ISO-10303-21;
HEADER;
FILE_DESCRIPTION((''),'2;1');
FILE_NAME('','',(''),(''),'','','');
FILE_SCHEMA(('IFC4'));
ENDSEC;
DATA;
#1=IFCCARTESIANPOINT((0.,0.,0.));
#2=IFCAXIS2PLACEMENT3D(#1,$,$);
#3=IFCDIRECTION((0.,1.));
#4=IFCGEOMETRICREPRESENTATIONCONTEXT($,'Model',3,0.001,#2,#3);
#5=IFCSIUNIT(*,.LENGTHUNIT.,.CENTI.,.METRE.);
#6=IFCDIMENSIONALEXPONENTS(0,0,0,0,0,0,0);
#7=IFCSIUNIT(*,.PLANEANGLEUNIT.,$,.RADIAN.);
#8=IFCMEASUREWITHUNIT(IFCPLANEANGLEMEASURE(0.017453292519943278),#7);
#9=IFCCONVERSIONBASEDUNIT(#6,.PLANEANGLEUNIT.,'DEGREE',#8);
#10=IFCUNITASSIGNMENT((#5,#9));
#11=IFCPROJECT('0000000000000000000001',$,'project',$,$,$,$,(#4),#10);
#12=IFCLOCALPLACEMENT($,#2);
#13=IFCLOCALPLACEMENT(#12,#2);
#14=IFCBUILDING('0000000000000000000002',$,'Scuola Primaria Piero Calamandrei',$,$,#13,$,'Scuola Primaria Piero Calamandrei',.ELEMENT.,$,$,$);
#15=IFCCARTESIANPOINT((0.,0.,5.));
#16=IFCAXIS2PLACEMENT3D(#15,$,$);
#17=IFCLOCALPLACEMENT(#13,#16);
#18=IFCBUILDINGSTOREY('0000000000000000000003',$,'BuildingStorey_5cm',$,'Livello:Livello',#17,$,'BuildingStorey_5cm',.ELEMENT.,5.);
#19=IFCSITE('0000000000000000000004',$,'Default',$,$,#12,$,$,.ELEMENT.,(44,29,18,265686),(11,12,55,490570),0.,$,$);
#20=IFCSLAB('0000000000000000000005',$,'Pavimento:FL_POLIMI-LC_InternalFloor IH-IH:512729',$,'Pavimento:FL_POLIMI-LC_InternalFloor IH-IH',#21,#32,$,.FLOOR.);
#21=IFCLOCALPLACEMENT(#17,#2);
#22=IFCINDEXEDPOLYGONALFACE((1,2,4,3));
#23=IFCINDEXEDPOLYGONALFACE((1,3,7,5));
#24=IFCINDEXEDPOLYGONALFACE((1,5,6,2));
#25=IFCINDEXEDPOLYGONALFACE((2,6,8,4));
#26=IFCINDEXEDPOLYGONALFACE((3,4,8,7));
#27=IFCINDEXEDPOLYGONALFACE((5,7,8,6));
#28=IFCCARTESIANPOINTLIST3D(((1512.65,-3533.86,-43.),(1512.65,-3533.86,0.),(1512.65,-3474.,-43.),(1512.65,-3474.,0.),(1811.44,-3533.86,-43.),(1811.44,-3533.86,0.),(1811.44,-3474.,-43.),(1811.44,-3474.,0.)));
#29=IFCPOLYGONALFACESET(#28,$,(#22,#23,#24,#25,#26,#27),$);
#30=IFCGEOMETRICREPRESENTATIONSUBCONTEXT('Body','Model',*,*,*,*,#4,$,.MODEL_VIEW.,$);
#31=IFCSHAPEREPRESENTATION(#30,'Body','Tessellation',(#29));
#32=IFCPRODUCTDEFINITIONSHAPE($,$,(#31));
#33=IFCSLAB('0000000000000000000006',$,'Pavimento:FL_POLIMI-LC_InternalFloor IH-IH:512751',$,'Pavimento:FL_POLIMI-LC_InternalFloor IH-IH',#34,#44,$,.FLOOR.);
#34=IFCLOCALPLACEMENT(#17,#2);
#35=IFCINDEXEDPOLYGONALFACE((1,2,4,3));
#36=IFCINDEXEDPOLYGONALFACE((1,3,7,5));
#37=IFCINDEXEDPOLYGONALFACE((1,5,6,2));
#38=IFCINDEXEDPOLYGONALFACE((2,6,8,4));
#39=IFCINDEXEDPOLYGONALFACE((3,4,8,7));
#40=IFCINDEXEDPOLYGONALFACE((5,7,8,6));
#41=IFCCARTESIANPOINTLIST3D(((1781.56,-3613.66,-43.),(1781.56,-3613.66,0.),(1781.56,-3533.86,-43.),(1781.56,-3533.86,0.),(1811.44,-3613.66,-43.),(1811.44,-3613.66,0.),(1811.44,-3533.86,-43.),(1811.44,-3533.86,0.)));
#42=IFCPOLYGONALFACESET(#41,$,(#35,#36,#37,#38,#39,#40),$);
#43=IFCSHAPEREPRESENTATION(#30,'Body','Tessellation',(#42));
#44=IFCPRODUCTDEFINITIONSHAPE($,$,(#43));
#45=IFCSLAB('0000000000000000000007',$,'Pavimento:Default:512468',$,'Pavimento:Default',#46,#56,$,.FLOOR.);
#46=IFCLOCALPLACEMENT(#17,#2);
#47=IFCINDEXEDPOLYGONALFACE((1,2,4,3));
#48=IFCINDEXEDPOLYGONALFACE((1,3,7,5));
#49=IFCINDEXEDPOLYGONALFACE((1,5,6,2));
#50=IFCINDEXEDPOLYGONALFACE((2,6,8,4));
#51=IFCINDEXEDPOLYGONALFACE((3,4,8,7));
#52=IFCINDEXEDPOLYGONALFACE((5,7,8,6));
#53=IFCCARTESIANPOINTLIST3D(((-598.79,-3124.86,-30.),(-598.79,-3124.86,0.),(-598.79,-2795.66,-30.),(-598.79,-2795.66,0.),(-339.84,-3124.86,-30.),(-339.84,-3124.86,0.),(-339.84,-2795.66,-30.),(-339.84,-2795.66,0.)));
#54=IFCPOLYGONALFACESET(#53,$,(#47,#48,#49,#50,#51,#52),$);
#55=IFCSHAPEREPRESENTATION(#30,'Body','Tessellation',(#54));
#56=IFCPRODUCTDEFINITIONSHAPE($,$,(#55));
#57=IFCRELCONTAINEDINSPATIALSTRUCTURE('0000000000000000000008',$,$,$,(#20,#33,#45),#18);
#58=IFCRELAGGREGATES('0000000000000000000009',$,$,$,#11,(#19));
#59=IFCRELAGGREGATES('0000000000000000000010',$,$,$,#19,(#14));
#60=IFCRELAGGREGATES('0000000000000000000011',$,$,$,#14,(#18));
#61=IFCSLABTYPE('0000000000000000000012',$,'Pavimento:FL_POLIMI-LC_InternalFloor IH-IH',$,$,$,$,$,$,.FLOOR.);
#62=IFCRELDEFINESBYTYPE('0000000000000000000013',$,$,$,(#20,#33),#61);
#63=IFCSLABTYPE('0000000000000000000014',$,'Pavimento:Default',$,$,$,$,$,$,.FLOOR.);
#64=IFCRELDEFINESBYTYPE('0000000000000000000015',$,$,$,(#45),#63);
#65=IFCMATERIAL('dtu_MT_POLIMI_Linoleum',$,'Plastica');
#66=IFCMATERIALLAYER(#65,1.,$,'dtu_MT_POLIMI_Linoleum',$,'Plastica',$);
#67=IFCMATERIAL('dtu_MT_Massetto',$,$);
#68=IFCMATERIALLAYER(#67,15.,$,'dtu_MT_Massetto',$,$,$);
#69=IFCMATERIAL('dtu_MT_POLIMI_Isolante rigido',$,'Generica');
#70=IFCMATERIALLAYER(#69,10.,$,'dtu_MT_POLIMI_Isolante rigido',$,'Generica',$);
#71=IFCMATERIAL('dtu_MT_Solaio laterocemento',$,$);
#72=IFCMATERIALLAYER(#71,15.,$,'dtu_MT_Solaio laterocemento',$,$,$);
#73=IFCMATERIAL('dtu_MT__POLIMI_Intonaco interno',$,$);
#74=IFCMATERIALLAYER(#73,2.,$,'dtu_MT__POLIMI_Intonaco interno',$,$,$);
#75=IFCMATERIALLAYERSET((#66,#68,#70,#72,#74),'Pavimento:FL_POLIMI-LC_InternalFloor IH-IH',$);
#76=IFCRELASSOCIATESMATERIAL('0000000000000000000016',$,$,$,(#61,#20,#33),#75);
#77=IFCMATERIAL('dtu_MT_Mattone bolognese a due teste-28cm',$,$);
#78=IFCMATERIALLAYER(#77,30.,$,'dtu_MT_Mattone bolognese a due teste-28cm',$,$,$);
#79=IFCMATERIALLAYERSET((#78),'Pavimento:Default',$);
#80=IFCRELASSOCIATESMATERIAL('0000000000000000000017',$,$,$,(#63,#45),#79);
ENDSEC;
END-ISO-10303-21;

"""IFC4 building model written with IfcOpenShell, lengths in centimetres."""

from ifc_helpers import new_model, entity, si_unit, converted_unit, direction, frame, frame_2d, origin, place, context, subcontext, project, spatial, rectangle, extrude, material, layer, layer_set, layer_usage, type_object, element, save


model = new_model("IFC4")

# Units and contexts
model_context = context("Model", 3, precision=0.001, world=origin(), true_north=direction((0.0, 1.0)))
body_context = subcontext(model_context, "Body", "Model", "MODEL_VIEW")
ifc_project = project(units=[si_unit("LENGTHUNIT", "METRE", prefix="CENTI"), converted_unit("PLANEANGLEUNIT", "DEGREE", entity("IfcPlaneAngleMeasure", 0.017453292519943278), si_unit("PLANEANGLEUNIT", "RADIAN"), dimensions=[0, 0, 0, 0, 0, 0, 0])], contexts=[model_context])

# Site, building, storey
site_placement = place(None, origin())
site = spatial("IfcSite", under=ifc_project, at=site_placement, Name="Default", CompositionType="ELEMENT", RefLatitude=(44, 29, 18, 265686), RefLongitude=(11, 12, 55, 490570), RefElevation=0.0)
building_placement = place(site_placement, origin())
building = spatial("IfcBuilding", under=site, at=building_placement, Name="Scuola Primaria Piero Calamandrei", LongName="Scuola Primaria Piero Calamandrei", CompositionType="ELEMENT")
storey_placement = place(building_placement, frame((0.0, 0.0, 5.0)))
storey = spatial("IfcBuildingStorey", under=building, at=storey_placement, Name="BuildingStorey_5cm", ObjectType="Livello:Livello", LongName="BuildingStorey_5cm", CompositionType="ELEMENT", Elevation=5.0)

# Slabs
ifc_material_1 = material(Name="dtu_MT_POLIMI_Linoleum", Category="Plastica")
ifc_layer_1 = layer(ifc_material_1, 1.0, Name="dtu_MT_POLIMI_Linoleum", Category="Plastica")
ifc_material_2 = material(Name="dtu_MT_Massetto")
ifc_layer_2 = layer(ifc_material_2, 15.0, Name="dtu_MT_Massetto")
ifc_material_3 = material(Name="dtu_MT_POLIMI_Isolante rigido", Category="Generica")
ifc_layer_3 = layer(ifc_material_3, 10.0, Name="dtu_MT_POLIMI_Isolante rigido", Category="Generica")
ifc_material_4 = material(Name="dtu_MT_Solaio laterocemento")
ifc_layer_4 = layer(ifc_material_4, 15.0, Name="dtu_MT_Solaio laterocemento")
ifc_material_5 = material(Name="dtu_MT__POLIMI_Intonaco interno")
ifc_layer_5 = layer(ifc_material_5, 2.0, Name="dtu_MT__POLIMI_Intonaco interno")
ifc_layer_set_1 = layer_set([ifc_layer_1, ifc_layer_2, ifc_layer_3, ifc_layer_4, ifc_layer_5], Name="Pavimento:FL_POLIMI-LC_InternalFloor IH-IH")
slab_type_1 = type_object("IfcSlabType", Name="Pavimento:FL_POLIMI-LC_InternalFloor IH-IH", PredefinedType="FLOOR", material=ifc_layer_set_1)
ifc_layer_usage_1 = layer_usage(ifc_layer_set_1, "AXIS3", "POSITIVE", 0.0)
slab_1_placement = place(storey_placement, origin())
element("IfcSlab", 1, at=slab_1_placement, inside=storey, type_object=slab_type_1, material=ifc_layer_usage_1, Name="Pavimento:FL_POLIMI-LC_InternalFloor IH-IH:512729", ObjectType="Pavimento:FL_POLIMI-LC_InternalFloor IH-IH", PredefinedType="FLOOR", context=body_context, shape_type="SweptSolid", body=[
    extrude(rectangle(XDim=59.85, YDim=298.79, at=frame_2d((0.0, 0.0), x_axis=(1.0, 0.0))), frame((1662.04, -3503.93, 0.0), z_axis=(0.0, 0.0, -1.0), x_axis=(0.0, 1.0, 0.0)), (0.0, 0.0, 1.0), 43.0),
])
ifc_layer_usage_2 = layer_usage(ifc_layer_set_1, "AXIS3", "POSITIVE", 0.0)
slab_2_placement = place(storey_placement, origin())
element("IfcSlab", 2, at=slab_2_placement, inside=storey, type_object=slab_type_1, material=ifc_layer_usage_2, Name="Pavimento:FL_POLIMI-LC_InternalFloor IH-IH:512751", ObjectType="Pavimento:FL_POLIMI-LC_InternalFloor IH-IH", PredefinedType="FLOOR", context=body_context, shape_type="SweptSolid", body=[
    extrude(rectangle(XDim=79.8, YDim=29.88, at=frame_2d((0.0, 0.0), x_axis=(1.0, 0.0))), frame((1796.5, -3573.76, 0.0), z_axis=(0.0, 0.0, -1.0), x_axis=(0.0, 1.0, 0.0)), (0.0, 0.0, 1.0), 43.0),
])
ifc_material_6 = material(Name="dtu_MT_Mattone bolognese a due teste-28cm")
ifc_layer_6 = layer(ifc_material_6, 30.0, Name="dtu_MT_Mattone bolognese a due teste-28cm")
ifc_layer_set_2 = layer_set([ifc_layer_6], Name="Pavimento:Default")
slab_type_2 = type_object("IfcSlabType", Name="Pavimento:Default", PredefinedType="FLOOR", material=ifc_layer_set_2)
ifc_layer_usage_3 = layer_usage(ifc_layer_set_2, "AXIS3", "POSITIVE", 0.0)
slab_3_placement = place(storey_placement, origin())
element("IfcSlab", 3, at=slab_3_placement, inside=storey, type_object=slab_type_2, material=ifc_layer_usage_3, Name="Pavimento:Default:512468", ObjectType="Pavimento:Default", PredefinedType="FLOOR", context=body_context, shape_type="SweptSolid", body=[
    extrude(rectangle(XDim=329.19, YDim=258.95, at=frame_2d((0.0, 0.0), x_axis=(1.0, 0.0))), frame((-469.32, -2960.26, 0.0), z_axis=(0.0, 0.0, -1.0), x_axis=(0.0, 1.0, 0.0)), (0.0, 0.0, 1.0), 30.0),
])

save(model, "model.ifc")
